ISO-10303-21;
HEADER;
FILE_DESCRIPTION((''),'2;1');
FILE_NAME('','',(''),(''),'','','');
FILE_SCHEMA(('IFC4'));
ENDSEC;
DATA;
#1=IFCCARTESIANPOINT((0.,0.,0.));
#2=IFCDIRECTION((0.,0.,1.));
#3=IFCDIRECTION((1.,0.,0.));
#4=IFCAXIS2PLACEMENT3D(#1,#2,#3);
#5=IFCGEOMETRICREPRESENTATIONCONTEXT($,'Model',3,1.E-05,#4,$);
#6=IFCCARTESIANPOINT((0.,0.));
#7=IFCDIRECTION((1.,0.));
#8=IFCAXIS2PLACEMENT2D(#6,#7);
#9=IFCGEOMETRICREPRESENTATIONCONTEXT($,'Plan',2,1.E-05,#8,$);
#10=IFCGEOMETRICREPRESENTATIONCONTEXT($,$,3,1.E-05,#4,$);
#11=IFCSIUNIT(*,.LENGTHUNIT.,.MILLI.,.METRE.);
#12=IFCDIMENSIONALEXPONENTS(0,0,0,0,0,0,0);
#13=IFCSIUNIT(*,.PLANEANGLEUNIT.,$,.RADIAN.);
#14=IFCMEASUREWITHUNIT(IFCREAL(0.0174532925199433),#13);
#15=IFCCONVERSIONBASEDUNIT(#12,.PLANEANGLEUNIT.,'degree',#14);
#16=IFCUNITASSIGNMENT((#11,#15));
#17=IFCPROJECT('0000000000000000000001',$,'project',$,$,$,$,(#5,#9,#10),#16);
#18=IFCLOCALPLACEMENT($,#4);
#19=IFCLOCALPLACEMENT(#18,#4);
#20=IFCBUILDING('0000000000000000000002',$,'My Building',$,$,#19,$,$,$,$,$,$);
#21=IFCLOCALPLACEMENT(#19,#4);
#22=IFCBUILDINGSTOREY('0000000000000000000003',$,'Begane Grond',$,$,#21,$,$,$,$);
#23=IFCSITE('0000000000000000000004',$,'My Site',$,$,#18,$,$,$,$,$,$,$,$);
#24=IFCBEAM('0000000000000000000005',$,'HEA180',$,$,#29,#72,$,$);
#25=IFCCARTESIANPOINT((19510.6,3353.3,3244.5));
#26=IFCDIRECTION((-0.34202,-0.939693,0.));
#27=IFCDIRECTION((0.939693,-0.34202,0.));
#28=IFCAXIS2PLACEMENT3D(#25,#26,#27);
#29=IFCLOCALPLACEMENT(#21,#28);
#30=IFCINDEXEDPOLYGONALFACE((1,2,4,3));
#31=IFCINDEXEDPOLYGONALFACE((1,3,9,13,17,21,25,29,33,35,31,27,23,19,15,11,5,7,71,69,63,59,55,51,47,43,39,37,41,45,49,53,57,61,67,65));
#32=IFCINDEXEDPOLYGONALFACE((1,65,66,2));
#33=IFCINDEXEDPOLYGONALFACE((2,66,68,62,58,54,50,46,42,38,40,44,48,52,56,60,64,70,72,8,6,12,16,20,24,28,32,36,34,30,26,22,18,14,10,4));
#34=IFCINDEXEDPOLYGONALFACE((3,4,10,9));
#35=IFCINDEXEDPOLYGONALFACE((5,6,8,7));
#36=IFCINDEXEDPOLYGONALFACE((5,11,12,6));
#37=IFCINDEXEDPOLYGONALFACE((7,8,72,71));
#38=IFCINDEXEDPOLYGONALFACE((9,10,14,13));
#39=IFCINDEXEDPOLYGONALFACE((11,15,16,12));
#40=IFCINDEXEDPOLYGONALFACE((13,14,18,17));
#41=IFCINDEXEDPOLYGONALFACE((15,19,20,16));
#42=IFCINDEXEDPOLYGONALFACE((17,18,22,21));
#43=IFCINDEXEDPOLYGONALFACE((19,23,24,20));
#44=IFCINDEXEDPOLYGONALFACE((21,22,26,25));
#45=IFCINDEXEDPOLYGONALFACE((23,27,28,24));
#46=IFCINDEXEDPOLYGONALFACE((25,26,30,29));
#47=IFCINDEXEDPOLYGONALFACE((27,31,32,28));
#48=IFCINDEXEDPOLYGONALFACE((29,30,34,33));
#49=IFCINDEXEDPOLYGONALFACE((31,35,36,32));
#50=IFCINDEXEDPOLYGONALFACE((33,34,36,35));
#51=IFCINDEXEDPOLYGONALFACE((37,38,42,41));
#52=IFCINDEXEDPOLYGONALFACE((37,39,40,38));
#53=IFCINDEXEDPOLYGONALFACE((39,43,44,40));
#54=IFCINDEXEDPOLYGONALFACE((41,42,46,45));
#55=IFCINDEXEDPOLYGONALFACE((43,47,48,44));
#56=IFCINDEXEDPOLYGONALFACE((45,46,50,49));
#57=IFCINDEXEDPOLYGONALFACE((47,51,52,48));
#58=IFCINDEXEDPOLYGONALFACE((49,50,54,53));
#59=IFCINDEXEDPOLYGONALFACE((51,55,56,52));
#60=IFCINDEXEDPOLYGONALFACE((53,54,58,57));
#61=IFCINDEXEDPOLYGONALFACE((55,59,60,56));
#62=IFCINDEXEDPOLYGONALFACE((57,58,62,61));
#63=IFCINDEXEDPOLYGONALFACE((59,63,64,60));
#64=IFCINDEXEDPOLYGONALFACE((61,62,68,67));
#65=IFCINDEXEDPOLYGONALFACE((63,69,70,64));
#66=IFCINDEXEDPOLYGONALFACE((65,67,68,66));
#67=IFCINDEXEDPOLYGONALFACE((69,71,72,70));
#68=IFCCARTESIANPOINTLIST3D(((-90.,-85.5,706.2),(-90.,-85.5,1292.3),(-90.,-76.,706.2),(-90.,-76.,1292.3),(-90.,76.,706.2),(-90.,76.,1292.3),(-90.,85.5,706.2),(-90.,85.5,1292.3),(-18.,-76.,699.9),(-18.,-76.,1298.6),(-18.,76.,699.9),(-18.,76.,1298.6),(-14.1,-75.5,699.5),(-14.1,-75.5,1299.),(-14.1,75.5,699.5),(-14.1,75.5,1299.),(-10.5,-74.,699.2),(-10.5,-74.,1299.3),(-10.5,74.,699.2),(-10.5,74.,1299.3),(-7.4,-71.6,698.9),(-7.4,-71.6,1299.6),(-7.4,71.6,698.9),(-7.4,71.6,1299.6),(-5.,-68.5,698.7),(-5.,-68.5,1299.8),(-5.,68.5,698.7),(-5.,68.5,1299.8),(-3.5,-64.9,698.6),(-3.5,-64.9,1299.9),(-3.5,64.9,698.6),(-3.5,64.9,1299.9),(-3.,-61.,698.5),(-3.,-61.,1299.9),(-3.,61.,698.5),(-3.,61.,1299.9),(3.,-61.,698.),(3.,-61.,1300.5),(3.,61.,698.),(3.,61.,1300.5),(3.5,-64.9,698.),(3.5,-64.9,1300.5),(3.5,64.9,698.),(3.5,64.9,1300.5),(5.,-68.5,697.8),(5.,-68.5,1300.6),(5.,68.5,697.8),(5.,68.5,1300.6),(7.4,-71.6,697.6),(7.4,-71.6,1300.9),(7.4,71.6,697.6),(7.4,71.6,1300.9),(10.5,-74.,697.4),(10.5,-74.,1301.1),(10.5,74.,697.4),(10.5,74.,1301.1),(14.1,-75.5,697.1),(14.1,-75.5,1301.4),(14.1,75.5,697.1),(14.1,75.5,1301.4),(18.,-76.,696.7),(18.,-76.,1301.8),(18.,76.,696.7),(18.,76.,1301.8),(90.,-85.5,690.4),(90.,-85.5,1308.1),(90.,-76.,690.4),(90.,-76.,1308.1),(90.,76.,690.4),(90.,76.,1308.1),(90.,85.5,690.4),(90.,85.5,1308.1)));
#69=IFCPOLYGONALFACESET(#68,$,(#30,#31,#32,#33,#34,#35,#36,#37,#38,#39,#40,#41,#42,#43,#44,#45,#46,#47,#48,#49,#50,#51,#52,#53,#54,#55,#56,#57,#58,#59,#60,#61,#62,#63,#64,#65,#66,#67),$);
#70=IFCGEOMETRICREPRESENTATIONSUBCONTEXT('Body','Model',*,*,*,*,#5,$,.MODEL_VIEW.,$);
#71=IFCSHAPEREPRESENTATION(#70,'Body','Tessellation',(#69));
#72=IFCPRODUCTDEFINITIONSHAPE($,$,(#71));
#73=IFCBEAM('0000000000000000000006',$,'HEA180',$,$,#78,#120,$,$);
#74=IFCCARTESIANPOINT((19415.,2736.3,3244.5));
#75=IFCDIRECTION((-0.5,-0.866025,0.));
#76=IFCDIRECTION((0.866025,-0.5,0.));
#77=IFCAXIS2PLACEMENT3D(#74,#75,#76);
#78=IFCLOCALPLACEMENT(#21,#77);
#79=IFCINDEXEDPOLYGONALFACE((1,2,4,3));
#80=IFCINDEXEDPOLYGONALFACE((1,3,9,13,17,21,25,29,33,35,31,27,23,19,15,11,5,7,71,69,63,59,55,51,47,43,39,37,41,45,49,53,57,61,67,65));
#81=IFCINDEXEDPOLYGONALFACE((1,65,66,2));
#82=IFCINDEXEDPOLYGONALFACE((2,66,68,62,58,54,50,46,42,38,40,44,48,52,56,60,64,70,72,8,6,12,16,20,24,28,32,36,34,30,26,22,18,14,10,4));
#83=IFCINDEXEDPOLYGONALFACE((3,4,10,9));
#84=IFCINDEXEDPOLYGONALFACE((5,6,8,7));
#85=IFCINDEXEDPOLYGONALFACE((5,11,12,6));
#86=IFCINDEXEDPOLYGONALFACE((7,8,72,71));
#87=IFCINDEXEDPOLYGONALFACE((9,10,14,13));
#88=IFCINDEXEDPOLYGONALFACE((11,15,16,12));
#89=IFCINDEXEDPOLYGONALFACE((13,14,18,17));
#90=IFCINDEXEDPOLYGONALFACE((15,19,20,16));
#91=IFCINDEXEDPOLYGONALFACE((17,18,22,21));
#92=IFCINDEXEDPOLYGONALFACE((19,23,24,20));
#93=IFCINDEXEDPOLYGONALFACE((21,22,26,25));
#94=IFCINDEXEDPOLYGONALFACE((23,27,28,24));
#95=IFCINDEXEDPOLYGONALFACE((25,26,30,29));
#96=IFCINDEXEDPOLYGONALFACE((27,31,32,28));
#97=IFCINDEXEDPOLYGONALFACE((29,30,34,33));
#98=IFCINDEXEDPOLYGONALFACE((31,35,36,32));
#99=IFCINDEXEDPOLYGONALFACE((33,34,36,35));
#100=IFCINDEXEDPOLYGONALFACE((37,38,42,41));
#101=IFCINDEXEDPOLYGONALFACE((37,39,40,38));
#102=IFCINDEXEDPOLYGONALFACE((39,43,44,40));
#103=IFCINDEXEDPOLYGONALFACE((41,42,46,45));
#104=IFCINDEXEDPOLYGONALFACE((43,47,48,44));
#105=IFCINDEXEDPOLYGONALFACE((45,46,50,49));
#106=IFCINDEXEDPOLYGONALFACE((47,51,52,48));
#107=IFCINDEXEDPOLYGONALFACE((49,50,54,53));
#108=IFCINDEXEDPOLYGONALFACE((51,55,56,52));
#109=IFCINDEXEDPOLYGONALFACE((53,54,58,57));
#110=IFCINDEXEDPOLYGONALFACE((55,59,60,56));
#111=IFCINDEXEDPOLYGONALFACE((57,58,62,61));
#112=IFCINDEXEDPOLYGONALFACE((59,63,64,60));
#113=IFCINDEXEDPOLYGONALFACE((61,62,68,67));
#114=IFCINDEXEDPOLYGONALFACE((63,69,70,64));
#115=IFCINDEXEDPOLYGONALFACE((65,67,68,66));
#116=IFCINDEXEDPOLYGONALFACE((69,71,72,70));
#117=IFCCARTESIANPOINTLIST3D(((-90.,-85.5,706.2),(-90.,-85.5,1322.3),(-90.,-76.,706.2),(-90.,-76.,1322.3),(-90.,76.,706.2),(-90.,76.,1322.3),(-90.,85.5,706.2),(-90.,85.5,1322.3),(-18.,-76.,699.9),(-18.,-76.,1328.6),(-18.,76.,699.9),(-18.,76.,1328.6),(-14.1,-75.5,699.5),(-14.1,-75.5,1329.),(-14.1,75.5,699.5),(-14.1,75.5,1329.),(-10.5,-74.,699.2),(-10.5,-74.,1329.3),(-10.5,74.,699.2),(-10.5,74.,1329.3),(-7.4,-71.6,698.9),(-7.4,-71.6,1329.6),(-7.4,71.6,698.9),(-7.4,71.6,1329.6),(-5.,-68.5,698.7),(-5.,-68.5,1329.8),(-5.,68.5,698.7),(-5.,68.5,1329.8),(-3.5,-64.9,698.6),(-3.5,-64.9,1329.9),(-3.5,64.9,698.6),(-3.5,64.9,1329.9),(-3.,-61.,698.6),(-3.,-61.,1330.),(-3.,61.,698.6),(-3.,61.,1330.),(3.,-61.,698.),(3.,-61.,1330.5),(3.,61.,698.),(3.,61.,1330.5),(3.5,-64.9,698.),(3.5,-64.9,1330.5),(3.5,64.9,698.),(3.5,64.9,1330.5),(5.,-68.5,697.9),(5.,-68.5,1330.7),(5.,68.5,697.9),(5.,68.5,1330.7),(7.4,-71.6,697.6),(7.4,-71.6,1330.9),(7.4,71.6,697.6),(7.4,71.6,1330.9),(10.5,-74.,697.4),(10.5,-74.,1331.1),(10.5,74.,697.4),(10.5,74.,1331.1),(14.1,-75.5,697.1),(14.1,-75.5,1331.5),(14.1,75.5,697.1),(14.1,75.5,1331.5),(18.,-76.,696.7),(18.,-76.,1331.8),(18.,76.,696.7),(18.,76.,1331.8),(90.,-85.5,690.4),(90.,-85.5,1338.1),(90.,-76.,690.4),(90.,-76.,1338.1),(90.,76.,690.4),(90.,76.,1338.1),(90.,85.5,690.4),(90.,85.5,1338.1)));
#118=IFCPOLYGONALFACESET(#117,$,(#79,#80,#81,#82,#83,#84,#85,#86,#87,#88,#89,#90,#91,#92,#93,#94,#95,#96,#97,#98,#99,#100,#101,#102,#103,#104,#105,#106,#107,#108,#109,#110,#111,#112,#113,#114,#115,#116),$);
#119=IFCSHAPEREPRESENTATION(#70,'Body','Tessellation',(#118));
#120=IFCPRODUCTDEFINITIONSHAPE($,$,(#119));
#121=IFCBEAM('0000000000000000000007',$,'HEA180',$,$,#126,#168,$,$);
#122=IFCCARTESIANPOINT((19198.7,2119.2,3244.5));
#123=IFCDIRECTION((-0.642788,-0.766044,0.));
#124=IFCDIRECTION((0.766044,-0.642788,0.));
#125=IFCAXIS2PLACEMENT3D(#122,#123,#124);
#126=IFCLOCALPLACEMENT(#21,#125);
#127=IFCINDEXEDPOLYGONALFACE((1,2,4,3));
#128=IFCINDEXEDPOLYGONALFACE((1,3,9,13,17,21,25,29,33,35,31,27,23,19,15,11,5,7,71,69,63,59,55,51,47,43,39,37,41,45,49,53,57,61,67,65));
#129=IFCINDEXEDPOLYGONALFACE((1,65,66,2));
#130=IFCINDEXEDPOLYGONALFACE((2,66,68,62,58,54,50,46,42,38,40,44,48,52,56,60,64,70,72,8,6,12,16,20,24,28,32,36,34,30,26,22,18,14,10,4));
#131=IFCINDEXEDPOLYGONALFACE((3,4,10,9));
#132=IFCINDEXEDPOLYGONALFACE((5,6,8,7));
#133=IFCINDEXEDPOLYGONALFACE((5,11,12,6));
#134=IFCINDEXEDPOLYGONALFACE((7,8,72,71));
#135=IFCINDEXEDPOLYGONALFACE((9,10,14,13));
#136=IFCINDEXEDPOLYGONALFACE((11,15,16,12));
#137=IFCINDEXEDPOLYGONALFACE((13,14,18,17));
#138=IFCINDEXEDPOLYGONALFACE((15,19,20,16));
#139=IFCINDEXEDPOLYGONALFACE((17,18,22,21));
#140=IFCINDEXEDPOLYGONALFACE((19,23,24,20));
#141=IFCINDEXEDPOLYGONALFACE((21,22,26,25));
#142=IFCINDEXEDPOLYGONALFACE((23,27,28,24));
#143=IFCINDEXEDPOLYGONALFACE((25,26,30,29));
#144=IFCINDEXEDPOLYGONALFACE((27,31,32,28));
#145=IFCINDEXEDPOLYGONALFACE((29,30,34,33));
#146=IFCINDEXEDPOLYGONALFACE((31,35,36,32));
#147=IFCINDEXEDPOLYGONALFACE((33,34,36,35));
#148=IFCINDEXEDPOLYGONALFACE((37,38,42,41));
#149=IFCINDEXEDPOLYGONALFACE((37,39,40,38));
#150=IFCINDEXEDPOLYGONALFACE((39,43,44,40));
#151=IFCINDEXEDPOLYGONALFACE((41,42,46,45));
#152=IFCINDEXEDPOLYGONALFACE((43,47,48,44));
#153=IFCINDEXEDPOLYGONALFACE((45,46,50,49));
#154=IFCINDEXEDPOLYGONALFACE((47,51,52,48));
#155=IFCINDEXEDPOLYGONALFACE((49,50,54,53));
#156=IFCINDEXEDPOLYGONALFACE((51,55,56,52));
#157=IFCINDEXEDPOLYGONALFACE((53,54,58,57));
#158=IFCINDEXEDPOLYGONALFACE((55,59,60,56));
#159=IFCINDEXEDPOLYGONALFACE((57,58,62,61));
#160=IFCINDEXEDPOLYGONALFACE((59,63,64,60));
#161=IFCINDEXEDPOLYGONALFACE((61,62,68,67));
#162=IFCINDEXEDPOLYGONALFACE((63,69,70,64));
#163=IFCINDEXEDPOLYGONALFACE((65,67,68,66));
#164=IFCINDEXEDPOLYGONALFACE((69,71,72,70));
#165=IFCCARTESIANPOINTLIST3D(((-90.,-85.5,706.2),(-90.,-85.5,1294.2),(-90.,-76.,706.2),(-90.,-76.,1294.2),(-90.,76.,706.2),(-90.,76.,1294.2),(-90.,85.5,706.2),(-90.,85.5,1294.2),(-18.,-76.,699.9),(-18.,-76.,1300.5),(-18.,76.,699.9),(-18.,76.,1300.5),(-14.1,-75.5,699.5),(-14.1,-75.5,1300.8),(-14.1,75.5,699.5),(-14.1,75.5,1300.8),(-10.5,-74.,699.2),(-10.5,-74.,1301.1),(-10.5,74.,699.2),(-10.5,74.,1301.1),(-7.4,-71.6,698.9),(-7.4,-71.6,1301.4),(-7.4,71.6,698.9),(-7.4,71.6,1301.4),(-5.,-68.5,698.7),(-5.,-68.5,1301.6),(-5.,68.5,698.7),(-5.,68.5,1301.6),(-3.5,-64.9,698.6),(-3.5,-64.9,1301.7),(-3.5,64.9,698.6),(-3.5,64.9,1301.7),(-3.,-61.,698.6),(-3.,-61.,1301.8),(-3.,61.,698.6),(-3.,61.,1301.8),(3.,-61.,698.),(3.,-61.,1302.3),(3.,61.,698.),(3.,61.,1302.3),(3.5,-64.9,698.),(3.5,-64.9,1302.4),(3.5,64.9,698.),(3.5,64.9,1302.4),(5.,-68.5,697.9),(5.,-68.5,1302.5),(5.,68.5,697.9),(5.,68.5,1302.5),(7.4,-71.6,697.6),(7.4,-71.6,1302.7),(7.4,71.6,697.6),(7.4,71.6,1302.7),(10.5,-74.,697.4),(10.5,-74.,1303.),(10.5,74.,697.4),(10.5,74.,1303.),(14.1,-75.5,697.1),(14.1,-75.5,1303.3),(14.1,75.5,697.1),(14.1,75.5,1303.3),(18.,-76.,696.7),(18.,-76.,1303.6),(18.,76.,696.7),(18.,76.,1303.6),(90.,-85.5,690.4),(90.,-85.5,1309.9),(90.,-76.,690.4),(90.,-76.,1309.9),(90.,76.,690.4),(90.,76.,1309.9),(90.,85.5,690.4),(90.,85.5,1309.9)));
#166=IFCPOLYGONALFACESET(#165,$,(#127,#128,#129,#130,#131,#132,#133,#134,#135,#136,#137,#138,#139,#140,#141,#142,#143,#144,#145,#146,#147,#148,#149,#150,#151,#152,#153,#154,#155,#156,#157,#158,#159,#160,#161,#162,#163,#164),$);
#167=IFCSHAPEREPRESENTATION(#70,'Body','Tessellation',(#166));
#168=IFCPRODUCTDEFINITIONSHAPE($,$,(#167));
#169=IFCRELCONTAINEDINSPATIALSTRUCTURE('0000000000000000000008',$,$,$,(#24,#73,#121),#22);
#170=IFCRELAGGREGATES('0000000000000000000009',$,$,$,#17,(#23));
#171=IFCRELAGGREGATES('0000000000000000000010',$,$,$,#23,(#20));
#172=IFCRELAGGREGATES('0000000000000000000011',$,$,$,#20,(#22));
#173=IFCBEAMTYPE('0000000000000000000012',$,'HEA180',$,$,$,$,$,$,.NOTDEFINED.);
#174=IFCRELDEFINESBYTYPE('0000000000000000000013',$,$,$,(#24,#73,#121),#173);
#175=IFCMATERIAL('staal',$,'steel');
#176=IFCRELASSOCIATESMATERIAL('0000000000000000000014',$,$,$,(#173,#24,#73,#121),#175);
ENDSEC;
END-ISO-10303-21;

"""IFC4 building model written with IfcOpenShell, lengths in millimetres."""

from ifc_helpers import new_model, entity, si_unit, converted_unit, frame, origin_with_axes, origin_2d_with_axis, place, context, subcontext, project, spatial, i_section, extrude, clip, halfspace, material, material_profile, profile_set, profile_usage, type_object, element, save


model = new_model("IFC4")

# Units and contexts
model_context = context("Model", 3, precision=1e-05, world=origin_with_axes())
plan_context = context("Plan", 2, precision=1e-05, world=origin_2d_with_axis())
context_of_model = context(None, 3, precision=1e-05, world=origin_with_axes())
body_context = subcontext(model_context, "Body", "Model", "MODEL_VIEW")
ifc_project = project(units=[si_unit("LENGTHUNIT", "METRE", prefix="MILLI"), converted_unit("PLANEANGLEUNIT", "degree", entity("IfcReal", 0.0174532925199433), si_unit("PLANEANGLEUNIT", "RADIAN"), dimensions=[0, 0, 0, 0, 0, 0, 0])], contexts=[model_context, plan_context, context_of_model])

# Site, building, storey
site_placement = place(None, origin_with_axes())
site = spatial("IfcSite", under=ifc_project, at=site_placement, Name="My Site")
building_placement = place(site_placement, origin_with_axes())
building = spatial("IfcBuilding", under=site, at=building_placement, Name="My Building")
storey_placement = place(building_placement, origin_with_axes())
storey = spatial("IfcBuildingStorey", under=building, at=storey_placement, Name="Begane Grond")

# Shared definitions
ifc_material = material(Name="staal", Category="steel")

# Beams
ifc_material_profile_1 = material_profile(ifc_material, i_section(OverallWidth=180.0, OverallDepth=171.0, WebThickness=6.0, FlangeThickness=9.5, FilletRadius=15.0))
ifc_profile_set_1 = profile_set([ifc_material_profile_1], Name="HEA180")
beam_type_1 = type_object("IfcBeamType", Name="HEA180", PredefinedType="NOTDEFINED", material=ifc_profile_set_1)
ifc_profile_usage_1 = profile_usage(ifc_profile_set_1)
beam_1_placement = place(storey_placement, frame((19510.6, 3353.3, 3244.5), z_axis=(-0.34202, -0.939693, 0.0), x_axis=(0.939693, -0.34202, 0.0)))
element("IfcBeam", 1, at=beam_1_placement, inside=storey, type_object=beam_type_1, material=ifc_profile_usage_1, Name="HEA180", context=body_context, shape_type="Clipping", body=[
    clip(clip(extrude(i_section(OverallWidth=180.0, OverallDepth=171.0, WebThickness=6.0, FlangeThickness=9.5, FilletRadius=15.0), origin_with_axes(), (0.0, 0.0, 1.0), 1998.5), halfspace(frame((90.0, -3254.0, 690.4), z_axis=(-0.087136, 0.0, -0.996196), x_axis=(0.0, 1.0, 0.0)), False)), halfspace(frame((90.0, -3254.0, 1308.1), z_axis=(-0.087123, 0.0, 0.996197), x_axis=(-0.000001, 1.0, 0.0)), False)),
])
ifc_profile_usage_2 = profile_usage(ifc_profile_set_1)
beam_2_placement = place(storey_placement, frame((19415.0, 2736.3, 3244.5), z_axis=(-0.5, -0.866025, 0.0), x_axis=(0.866025, -0.5, 0.0)))
element("IfcBeam", 2, at=beam_2_placement, inside=storey, type_object=beam_type_1, material=ifc_profile_usage_2, Name="HEA180", context=body_context, shape_type="Clipping", body=[
    clip(clip(extrude(i_section(OverallWidth=180.0, OverallDepth=171.0, WebThickness=6.0, FlangeThickness=9.5, FilletRadius=15.0), origin_with_axes(), (0.0, 0.0, 1.0), 2028.5), halfspace(frame((90.0, -3254.0, 690.4), z_axis=(-0.087187, 0.0, -0.996192), x_axis=(0.000001, 1.0, 0.0)), False)), halfspace(frame((90.0, -3254.0, 1338.1), z_axis=(-0.087204, 0.0, 0.99619), x_axis=(-0.000001, 1.0, 0.0)), False)),
])
ifc_profile_usage_3 = profile_usage(ifc_profile_set_1)
beam_3_placement = place(storey_placement, frame((19198.7, 2119.2, 3244.5), z_axis=(-0.642788, -0.766044, 0.0), x_axis=(0.766044, -0.642788, 0.0)))
element("IfcBeam", 3, at=beam_3_placement, inside=storey, type_object=beam_type_1, material=ifc_profile_usage_3, Name="HEA180", context=body_context, shape_type="Clipping", body=[
    clip(clip(extrude(i_section(OverallWidth=180.0, OverallDepth=171.0, WebThickness=6.0, FlangeThickness=9.5, FilletRadius=15.0), origin_with_axes(), (0.0, 0.0, 1.0), 2000.3), halfspace(frame((90.0, -3254.0, 690.4), z_axis=(-0.087149, 0.0, -0.996195), x_axis=(0.000001, 1.0, 0.0)), False)), halfspace(frame((90.0, -3254.0, 1309.9), z_axis=(-0.087193, 0.0, 0.996191), x_axis=(-0.000001, 1.0, 0.0)), False)),
])

save(model, "model.ifc")
